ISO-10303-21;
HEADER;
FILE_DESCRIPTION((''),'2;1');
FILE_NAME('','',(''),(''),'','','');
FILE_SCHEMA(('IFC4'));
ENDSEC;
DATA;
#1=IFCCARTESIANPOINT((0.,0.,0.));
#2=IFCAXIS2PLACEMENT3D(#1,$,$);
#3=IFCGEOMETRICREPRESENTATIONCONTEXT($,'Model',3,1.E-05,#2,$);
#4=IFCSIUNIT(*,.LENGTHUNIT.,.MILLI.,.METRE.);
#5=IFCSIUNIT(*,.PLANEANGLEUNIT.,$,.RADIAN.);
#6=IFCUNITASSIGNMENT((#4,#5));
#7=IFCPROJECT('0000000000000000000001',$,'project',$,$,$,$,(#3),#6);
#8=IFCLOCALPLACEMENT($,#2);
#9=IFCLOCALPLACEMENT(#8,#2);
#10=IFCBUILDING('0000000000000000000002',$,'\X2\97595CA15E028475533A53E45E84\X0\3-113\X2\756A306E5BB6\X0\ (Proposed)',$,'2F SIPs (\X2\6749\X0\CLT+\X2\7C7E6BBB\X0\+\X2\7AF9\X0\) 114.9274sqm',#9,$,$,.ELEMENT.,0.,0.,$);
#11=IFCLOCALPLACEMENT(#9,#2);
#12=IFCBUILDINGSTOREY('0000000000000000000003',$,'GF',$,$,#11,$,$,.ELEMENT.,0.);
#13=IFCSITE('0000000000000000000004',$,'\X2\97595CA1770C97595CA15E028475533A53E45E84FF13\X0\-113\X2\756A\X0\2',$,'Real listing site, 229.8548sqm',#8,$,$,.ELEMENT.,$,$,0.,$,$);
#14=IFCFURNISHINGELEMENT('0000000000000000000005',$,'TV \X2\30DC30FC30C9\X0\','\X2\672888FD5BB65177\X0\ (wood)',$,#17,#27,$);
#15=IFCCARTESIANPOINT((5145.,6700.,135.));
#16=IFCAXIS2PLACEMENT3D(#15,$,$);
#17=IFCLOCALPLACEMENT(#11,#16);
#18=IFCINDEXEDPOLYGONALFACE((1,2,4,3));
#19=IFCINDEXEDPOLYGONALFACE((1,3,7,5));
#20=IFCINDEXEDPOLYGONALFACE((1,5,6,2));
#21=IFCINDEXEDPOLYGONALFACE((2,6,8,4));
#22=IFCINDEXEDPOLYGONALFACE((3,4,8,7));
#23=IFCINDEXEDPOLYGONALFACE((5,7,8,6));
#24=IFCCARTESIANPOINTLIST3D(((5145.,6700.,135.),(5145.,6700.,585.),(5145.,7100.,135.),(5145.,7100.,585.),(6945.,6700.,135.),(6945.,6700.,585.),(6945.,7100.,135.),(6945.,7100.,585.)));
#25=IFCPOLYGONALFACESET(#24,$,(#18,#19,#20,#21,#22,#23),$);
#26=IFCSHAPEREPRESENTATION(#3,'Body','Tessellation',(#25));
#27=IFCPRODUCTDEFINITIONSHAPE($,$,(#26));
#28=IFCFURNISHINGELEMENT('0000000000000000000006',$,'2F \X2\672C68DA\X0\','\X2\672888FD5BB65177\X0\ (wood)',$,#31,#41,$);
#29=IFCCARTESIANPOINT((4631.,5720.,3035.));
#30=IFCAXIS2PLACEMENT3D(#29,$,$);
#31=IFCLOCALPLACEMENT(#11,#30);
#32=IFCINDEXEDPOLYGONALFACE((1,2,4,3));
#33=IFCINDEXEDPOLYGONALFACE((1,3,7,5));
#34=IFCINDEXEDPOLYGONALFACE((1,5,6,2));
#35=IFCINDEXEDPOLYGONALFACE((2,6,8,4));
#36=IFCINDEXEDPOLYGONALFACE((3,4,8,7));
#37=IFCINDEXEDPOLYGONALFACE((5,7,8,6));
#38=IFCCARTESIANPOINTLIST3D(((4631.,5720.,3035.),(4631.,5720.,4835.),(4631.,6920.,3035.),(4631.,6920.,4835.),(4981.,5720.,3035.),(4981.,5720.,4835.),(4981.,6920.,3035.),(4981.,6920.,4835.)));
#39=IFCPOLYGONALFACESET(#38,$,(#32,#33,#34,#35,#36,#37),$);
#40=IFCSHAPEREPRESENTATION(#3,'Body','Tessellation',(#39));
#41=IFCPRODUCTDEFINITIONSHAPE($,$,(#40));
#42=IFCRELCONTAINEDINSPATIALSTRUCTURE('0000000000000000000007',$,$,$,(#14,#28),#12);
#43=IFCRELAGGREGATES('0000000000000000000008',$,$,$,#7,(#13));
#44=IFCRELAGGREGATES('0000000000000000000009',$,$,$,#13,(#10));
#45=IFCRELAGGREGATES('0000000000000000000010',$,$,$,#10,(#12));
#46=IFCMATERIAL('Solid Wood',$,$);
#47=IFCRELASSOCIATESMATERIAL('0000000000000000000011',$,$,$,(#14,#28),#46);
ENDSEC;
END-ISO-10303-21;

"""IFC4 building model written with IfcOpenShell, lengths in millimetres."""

from ifc_helpers import new_model, si_unit, frame, frame_2d, origin, place, context, project, spatial, rectangle, extrude, material, element, save


model = new_model("IFC4")

# Units and contexts
model_context = context("Model", 3, precision=1e-05, world=origin())
ifc_project = project(units=[si_unit("LENGTHUNIT", "METRE", prefix="MILLI"), si_unit("PLANEANGLEUNIT", "RADIAN")], contexts=[model_context])

# Site, building, storey
site_placement = place(None, origin())
site = spatial("IfcSite", under=ifc_project, at=site_placement, Name="静岡県静岡市葵区古庄３-113番2", ObjectType="Real listing site, 229.8548sqm", CompositionType="ELEMENT", RefElevation=0.0)
building_placement = place(site_placement, origin())
building = spatial("IfcBuilding", under=site, at=building_placement, Name="静岡市葵区古庄3-113番の家 (Proposed)", ObjectType="2F SIPs (杉CLT+籾殻+竹) 114.9274sqm", CompositionType="ELEMENT", ElevationOfRefHeight=0.0, ElevationOfTerrain=0.0)
storey_placement = place(building_placement, origin())
storey = spatial("IfcBuildingStorey", under=building, at=storey_placement, Name="GF", CompositionType="ELEMENT", Elevation=0.0)

# Shared definitions
ifc_material_1 = material(Name="Solid Wood")

# Furnishing elements
furnishing_1_placement = place(storey_placement, frame((5145.0, 6700.0, 135.0)))
element("IfcFurnishingElement", 1, at=furnishing_1_placement, inside=storey, material=ifc_material_1, Name="TV ボード", Description="木製家具 (wood)", context=model_context, shape_type="SweptSolid", body=[
    extrude(rectangle(XDim=1800.0, YDim=400.0, at=frame_2d((900.0, 200.0))), frame((5145.0, 6700.0, 135.0)), (0.0, 0.0, 1.0), 450.0),
])
furnishing_2_placement = place(storey_placement, frame((4631.0, 5720.0, 3035.0)))
element("IfcFurnishingElement", 2, at=furnishing_2_placement, inside=storey, material=ifc_material_1, Name="2F 本棚", Description="木製家具 (wood)", context=model_context, shape_type="SweptSolid", body=[
    extrude(rectangle(XDim=350.0, YDim=1200.0, at=frame_2d((175.0, 600.0))), frame((4631.0, 5720.0, 3035.0)), (0.0, 0.0, 1.0), 1800.0),
])

save(model, "model.ifc")
